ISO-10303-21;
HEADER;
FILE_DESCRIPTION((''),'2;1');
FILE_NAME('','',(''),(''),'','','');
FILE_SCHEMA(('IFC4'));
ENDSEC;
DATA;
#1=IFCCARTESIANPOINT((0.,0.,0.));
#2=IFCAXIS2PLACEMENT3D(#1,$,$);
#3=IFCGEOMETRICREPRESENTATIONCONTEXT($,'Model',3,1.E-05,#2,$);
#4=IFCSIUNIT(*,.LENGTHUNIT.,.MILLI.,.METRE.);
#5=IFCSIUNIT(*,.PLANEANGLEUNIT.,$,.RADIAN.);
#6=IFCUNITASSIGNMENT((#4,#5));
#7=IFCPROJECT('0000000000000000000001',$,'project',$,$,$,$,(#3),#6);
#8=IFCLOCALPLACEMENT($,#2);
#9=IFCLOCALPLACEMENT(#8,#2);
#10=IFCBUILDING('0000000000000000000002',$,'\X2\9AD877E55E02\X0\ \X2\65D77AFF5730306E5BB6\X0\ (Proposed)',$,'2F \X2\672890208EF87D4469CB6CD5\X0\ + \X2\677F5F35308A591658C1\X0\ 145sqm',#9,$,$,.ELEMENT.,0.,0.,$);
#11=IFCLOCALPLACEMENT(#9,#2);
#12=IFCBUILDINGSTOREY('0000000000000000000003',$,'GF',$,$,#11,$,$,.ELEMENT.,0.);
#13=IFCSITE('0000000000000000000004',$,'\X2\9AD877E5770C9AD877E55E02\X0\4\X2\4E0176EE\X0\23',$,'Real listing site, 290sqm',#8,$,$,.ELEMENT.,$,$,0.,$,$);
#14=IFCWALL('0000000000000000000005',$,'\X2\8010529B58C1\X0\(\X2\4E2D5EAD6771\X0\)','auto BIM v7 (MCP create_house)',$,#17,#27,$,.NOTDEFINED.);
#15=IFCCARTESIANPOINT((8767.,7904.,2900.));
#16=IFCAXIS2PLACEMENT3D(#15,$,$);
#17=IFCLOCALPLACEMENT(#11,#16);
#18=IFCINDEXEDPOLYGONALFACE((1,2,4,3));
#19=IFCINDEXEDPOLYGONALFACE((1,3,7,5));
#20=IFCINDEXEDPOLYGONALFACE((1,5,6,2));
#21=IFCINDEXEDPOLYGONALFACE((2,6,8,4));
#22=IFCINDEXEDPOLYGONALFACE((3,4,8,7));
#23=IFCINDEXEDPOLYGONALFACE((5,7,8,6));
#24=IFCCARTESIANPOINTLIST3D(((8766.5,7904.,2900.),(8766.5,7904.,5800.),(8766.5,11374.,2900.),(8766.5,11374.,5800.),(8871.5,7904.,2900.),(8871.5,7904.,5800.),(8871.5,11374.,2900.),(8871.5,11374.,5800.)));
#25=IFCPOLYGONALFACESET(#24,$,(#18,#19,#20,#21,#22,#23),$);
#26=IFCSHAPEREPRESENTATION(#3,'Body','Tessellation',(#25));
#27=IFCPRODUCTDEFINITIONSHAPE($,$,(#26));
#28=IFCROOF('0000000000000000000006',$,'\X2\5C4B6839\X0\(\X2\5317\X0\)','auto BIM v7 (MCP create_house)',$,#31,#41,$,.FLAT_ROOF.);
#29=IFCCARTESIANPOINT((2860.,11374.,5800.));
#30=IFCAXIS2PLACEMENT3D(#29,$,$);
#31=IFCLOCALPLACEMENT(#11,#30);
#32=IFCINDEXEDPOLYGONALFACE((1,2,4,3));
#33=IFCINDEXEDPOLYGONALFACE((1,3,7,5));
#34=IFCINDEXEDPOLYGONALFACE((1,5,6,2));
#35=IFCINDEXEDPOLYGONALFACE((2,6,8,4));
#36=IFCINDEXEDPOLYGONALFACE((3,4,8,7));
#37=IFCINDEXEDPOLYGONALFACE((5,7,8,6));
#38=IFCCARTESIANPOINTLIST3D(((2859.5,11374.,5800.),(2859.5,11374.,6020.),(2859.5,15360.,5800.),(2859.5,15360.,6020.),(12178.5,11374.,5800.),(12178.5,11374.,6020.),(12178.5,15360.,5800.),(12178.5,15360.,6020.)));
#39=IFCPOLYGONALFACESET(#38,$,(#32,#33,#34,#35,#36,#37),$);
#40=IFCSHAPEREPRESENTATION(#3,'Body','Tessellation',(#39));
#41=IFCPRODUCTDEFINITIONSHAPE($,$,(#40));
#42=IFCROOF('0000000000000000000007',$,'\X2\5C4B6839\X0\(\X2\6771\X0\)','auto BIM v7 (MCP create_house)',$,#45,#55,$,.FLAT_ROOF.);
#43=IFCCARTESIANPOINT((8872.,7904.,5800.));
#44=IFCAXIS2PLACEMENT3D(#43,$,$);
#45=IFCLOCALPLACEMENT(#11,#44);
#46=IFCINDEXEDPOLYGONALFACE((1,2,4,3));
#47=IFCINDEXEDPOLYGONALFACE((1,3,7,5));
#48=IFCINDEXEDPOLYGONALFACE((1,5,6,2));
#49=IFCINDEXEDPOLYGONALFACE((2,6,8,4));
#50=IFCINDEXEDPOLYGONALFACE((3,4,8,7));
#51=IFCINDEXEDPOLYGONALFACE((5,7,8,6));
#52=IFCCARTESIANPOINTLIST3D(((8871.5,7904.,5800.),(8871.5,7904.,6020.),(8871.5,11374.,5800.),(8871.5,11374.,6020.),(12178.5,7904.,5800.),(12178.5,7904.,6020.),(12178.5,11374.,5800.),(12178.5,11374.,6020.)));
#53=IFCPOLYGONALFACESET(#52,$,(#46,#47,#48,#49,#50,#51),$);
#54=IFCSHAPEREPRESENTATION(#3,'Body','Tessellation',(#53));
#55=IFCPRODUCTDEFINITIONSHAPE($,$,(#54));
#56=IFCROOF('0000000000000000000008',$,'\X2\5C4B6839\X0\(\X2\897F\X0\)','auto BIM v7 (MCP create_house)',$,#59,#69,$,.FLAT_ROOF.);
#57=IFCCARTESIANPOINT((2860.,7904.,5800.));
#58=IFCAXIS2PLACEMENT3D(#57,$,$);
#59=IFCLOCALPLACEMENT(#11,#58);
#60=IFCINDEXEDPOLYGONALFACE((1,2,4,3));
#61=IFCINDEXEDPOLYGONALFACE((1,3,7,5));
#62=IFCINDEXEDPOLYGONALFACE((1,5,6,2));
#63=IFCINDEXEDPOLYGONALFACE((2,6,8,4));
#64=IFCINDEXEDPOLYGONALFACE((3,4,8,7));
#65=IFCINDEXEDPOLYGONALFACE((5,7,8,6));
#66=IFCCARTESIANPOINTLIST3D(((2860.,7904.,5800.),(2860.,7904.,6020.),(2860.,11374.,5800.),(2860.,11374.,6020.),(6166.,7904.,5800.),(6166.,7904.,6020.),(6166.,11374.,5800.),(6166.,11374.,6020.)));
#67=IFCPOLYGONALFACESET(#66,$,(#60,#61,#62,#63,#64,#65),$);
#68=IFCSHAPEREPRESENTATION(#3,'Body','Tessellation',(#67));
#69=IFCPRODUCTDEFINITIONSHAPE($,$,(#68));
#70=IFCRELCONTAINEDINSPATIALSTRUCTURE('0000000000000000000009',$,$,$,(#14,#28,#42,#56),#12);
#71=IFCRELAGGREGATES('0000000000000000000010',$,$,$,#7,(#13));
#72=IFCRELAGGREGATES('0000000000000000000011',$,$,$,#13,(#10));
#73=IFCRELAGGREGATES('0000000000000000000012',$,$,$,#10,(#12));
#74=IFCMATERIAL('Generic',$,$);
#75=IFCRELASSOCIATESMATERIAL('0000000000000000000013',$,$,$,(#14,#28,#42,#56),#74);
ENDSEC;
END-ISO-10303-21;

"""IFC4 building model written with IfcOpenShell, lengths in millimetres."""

from ifc_helpers import new_model, si_unit, frame, frame_2d, origin, place, context, project, spatial, rectangle, extrude, material, element, save


model = new_model("IFC4")

# Units and contexts
model_context = context("Model", 3, precision=1e-05, world=origin())
ifc_project = project(units=[si_unit("LENGTHUNIT", "METRE", prefix="MILLI"), si_unit("PLANEANGLEUNIT", "RADIAN")], contexts=[model_context])

# Site, building, storey
site_placement = place(None, origin())
site = spatial("IfcSite", under=ifc_project, at=site_placement, Name="高知県高知市4丁目23", ObjectType="Real listing site, 290sqm", CompositionType="ELEMENT", RefElevation=0.0)
building_placement = place(site_placement, origin())
building = spatial("IfcBuilding", under=site, at=building_placement, Name="高知市 旗竿地の家 (Proposed)", ObjectType="2F 木造軸組構法 + 板張り外壁 145sqm", CompositionType="ELEMENT", ElevationOfRefHeight=0.0, ElevationOfTerrain=0.0)
storey_placement = place(building_placement, origin())
storey = spatial("IfcBuildingStorey", under=building, at=storey_placement, Name="GF", CompositionType="ELEMENT", Elevation=0.0)

# Shared definitions
ifc_material = material(Name="Generic")

# Wall
wall_1_placement = place(storey_placement, frame((8767.0, 7904.0, 2900.0)))
element("IfcWall", 1, at=wall_1_placement, inside=storey, material=ifc_material, Name="耐力壁(中庭東)", Description="auto BIM v7 (MCP create_house)", PredefinedType="NOTDEFINED", context=model_context, shape_type="SweptSolid", body=[
    extrude(rectangle(XDim=105.0, YDim=3470.0, at=frame_2d((52.0, 1735.0))), frame((8767.0, 7904.0, 2900.0)), (0.0, 0.0, 1.0), 2900.0),
])

# Roofs
roof_1_placement = place(storey_placement, frame((2860.0, 11374.0, 5800.0)))
element("IfcRoof", 2, at=roof_1_placement, inside=storey, material=ifc_material, Name="屋根(北)", Description="auto BIM v7 (MCP create_house)", PredefinedType="FLAT_ROOF", context=model_context, shape_type="SweptSolid", body=[
    extrude(rectangle(XDim=9319.0, YDim=3986.0, at=frame_2d((4659.0, 1993.0))), frame((2860.0, 11374.0, 5800.0)), (0.0, 0.0, 1.0), 220.0),
])
roof_2_placement = place(storey_placement, frame((8872.0, 7904.0, 5800.0)))
element("IfcRoof", 3, at=roof_2_placement, inside=storey, material=ifc_material, Name="屋根(東)", Description="auto BIM v7 (MCP create_house)", PredefinedType="FLAT_ROOF", context=model_context, shape_type="SweptSolid", body=[
    extrude(rectangle(XDim=3307.0, YDim=3470.0, at=frame_2d((1653.0, 1735.0))), frame((8872.0, 7904.0, 5800.0)), (0.0, 0.0, 1.0), 220.0),
])
roof_3_placement = place(storey_placement, frame((2860.0, 7904.0, 5800.0)))
element("IfcRoof", 4, at=roof_3_placement, inside=storey, material=ifc_material, Name="屋根(西)", Description="auto BIM v7 (MCP create_house)", PredefinedType="FLAT_ROOF", context=model_context, shape_type="SweptSolid", body=[
    extrude(rectangle(XDim=3306.0, YDim=3470.0, at=frame_2d((1653.0, 1735.0))), frame((2860.0, 7904.0, 5800.0)), (0.0, 0.0, 1.0), 220.0),
])

save(model, "model.ifc")
